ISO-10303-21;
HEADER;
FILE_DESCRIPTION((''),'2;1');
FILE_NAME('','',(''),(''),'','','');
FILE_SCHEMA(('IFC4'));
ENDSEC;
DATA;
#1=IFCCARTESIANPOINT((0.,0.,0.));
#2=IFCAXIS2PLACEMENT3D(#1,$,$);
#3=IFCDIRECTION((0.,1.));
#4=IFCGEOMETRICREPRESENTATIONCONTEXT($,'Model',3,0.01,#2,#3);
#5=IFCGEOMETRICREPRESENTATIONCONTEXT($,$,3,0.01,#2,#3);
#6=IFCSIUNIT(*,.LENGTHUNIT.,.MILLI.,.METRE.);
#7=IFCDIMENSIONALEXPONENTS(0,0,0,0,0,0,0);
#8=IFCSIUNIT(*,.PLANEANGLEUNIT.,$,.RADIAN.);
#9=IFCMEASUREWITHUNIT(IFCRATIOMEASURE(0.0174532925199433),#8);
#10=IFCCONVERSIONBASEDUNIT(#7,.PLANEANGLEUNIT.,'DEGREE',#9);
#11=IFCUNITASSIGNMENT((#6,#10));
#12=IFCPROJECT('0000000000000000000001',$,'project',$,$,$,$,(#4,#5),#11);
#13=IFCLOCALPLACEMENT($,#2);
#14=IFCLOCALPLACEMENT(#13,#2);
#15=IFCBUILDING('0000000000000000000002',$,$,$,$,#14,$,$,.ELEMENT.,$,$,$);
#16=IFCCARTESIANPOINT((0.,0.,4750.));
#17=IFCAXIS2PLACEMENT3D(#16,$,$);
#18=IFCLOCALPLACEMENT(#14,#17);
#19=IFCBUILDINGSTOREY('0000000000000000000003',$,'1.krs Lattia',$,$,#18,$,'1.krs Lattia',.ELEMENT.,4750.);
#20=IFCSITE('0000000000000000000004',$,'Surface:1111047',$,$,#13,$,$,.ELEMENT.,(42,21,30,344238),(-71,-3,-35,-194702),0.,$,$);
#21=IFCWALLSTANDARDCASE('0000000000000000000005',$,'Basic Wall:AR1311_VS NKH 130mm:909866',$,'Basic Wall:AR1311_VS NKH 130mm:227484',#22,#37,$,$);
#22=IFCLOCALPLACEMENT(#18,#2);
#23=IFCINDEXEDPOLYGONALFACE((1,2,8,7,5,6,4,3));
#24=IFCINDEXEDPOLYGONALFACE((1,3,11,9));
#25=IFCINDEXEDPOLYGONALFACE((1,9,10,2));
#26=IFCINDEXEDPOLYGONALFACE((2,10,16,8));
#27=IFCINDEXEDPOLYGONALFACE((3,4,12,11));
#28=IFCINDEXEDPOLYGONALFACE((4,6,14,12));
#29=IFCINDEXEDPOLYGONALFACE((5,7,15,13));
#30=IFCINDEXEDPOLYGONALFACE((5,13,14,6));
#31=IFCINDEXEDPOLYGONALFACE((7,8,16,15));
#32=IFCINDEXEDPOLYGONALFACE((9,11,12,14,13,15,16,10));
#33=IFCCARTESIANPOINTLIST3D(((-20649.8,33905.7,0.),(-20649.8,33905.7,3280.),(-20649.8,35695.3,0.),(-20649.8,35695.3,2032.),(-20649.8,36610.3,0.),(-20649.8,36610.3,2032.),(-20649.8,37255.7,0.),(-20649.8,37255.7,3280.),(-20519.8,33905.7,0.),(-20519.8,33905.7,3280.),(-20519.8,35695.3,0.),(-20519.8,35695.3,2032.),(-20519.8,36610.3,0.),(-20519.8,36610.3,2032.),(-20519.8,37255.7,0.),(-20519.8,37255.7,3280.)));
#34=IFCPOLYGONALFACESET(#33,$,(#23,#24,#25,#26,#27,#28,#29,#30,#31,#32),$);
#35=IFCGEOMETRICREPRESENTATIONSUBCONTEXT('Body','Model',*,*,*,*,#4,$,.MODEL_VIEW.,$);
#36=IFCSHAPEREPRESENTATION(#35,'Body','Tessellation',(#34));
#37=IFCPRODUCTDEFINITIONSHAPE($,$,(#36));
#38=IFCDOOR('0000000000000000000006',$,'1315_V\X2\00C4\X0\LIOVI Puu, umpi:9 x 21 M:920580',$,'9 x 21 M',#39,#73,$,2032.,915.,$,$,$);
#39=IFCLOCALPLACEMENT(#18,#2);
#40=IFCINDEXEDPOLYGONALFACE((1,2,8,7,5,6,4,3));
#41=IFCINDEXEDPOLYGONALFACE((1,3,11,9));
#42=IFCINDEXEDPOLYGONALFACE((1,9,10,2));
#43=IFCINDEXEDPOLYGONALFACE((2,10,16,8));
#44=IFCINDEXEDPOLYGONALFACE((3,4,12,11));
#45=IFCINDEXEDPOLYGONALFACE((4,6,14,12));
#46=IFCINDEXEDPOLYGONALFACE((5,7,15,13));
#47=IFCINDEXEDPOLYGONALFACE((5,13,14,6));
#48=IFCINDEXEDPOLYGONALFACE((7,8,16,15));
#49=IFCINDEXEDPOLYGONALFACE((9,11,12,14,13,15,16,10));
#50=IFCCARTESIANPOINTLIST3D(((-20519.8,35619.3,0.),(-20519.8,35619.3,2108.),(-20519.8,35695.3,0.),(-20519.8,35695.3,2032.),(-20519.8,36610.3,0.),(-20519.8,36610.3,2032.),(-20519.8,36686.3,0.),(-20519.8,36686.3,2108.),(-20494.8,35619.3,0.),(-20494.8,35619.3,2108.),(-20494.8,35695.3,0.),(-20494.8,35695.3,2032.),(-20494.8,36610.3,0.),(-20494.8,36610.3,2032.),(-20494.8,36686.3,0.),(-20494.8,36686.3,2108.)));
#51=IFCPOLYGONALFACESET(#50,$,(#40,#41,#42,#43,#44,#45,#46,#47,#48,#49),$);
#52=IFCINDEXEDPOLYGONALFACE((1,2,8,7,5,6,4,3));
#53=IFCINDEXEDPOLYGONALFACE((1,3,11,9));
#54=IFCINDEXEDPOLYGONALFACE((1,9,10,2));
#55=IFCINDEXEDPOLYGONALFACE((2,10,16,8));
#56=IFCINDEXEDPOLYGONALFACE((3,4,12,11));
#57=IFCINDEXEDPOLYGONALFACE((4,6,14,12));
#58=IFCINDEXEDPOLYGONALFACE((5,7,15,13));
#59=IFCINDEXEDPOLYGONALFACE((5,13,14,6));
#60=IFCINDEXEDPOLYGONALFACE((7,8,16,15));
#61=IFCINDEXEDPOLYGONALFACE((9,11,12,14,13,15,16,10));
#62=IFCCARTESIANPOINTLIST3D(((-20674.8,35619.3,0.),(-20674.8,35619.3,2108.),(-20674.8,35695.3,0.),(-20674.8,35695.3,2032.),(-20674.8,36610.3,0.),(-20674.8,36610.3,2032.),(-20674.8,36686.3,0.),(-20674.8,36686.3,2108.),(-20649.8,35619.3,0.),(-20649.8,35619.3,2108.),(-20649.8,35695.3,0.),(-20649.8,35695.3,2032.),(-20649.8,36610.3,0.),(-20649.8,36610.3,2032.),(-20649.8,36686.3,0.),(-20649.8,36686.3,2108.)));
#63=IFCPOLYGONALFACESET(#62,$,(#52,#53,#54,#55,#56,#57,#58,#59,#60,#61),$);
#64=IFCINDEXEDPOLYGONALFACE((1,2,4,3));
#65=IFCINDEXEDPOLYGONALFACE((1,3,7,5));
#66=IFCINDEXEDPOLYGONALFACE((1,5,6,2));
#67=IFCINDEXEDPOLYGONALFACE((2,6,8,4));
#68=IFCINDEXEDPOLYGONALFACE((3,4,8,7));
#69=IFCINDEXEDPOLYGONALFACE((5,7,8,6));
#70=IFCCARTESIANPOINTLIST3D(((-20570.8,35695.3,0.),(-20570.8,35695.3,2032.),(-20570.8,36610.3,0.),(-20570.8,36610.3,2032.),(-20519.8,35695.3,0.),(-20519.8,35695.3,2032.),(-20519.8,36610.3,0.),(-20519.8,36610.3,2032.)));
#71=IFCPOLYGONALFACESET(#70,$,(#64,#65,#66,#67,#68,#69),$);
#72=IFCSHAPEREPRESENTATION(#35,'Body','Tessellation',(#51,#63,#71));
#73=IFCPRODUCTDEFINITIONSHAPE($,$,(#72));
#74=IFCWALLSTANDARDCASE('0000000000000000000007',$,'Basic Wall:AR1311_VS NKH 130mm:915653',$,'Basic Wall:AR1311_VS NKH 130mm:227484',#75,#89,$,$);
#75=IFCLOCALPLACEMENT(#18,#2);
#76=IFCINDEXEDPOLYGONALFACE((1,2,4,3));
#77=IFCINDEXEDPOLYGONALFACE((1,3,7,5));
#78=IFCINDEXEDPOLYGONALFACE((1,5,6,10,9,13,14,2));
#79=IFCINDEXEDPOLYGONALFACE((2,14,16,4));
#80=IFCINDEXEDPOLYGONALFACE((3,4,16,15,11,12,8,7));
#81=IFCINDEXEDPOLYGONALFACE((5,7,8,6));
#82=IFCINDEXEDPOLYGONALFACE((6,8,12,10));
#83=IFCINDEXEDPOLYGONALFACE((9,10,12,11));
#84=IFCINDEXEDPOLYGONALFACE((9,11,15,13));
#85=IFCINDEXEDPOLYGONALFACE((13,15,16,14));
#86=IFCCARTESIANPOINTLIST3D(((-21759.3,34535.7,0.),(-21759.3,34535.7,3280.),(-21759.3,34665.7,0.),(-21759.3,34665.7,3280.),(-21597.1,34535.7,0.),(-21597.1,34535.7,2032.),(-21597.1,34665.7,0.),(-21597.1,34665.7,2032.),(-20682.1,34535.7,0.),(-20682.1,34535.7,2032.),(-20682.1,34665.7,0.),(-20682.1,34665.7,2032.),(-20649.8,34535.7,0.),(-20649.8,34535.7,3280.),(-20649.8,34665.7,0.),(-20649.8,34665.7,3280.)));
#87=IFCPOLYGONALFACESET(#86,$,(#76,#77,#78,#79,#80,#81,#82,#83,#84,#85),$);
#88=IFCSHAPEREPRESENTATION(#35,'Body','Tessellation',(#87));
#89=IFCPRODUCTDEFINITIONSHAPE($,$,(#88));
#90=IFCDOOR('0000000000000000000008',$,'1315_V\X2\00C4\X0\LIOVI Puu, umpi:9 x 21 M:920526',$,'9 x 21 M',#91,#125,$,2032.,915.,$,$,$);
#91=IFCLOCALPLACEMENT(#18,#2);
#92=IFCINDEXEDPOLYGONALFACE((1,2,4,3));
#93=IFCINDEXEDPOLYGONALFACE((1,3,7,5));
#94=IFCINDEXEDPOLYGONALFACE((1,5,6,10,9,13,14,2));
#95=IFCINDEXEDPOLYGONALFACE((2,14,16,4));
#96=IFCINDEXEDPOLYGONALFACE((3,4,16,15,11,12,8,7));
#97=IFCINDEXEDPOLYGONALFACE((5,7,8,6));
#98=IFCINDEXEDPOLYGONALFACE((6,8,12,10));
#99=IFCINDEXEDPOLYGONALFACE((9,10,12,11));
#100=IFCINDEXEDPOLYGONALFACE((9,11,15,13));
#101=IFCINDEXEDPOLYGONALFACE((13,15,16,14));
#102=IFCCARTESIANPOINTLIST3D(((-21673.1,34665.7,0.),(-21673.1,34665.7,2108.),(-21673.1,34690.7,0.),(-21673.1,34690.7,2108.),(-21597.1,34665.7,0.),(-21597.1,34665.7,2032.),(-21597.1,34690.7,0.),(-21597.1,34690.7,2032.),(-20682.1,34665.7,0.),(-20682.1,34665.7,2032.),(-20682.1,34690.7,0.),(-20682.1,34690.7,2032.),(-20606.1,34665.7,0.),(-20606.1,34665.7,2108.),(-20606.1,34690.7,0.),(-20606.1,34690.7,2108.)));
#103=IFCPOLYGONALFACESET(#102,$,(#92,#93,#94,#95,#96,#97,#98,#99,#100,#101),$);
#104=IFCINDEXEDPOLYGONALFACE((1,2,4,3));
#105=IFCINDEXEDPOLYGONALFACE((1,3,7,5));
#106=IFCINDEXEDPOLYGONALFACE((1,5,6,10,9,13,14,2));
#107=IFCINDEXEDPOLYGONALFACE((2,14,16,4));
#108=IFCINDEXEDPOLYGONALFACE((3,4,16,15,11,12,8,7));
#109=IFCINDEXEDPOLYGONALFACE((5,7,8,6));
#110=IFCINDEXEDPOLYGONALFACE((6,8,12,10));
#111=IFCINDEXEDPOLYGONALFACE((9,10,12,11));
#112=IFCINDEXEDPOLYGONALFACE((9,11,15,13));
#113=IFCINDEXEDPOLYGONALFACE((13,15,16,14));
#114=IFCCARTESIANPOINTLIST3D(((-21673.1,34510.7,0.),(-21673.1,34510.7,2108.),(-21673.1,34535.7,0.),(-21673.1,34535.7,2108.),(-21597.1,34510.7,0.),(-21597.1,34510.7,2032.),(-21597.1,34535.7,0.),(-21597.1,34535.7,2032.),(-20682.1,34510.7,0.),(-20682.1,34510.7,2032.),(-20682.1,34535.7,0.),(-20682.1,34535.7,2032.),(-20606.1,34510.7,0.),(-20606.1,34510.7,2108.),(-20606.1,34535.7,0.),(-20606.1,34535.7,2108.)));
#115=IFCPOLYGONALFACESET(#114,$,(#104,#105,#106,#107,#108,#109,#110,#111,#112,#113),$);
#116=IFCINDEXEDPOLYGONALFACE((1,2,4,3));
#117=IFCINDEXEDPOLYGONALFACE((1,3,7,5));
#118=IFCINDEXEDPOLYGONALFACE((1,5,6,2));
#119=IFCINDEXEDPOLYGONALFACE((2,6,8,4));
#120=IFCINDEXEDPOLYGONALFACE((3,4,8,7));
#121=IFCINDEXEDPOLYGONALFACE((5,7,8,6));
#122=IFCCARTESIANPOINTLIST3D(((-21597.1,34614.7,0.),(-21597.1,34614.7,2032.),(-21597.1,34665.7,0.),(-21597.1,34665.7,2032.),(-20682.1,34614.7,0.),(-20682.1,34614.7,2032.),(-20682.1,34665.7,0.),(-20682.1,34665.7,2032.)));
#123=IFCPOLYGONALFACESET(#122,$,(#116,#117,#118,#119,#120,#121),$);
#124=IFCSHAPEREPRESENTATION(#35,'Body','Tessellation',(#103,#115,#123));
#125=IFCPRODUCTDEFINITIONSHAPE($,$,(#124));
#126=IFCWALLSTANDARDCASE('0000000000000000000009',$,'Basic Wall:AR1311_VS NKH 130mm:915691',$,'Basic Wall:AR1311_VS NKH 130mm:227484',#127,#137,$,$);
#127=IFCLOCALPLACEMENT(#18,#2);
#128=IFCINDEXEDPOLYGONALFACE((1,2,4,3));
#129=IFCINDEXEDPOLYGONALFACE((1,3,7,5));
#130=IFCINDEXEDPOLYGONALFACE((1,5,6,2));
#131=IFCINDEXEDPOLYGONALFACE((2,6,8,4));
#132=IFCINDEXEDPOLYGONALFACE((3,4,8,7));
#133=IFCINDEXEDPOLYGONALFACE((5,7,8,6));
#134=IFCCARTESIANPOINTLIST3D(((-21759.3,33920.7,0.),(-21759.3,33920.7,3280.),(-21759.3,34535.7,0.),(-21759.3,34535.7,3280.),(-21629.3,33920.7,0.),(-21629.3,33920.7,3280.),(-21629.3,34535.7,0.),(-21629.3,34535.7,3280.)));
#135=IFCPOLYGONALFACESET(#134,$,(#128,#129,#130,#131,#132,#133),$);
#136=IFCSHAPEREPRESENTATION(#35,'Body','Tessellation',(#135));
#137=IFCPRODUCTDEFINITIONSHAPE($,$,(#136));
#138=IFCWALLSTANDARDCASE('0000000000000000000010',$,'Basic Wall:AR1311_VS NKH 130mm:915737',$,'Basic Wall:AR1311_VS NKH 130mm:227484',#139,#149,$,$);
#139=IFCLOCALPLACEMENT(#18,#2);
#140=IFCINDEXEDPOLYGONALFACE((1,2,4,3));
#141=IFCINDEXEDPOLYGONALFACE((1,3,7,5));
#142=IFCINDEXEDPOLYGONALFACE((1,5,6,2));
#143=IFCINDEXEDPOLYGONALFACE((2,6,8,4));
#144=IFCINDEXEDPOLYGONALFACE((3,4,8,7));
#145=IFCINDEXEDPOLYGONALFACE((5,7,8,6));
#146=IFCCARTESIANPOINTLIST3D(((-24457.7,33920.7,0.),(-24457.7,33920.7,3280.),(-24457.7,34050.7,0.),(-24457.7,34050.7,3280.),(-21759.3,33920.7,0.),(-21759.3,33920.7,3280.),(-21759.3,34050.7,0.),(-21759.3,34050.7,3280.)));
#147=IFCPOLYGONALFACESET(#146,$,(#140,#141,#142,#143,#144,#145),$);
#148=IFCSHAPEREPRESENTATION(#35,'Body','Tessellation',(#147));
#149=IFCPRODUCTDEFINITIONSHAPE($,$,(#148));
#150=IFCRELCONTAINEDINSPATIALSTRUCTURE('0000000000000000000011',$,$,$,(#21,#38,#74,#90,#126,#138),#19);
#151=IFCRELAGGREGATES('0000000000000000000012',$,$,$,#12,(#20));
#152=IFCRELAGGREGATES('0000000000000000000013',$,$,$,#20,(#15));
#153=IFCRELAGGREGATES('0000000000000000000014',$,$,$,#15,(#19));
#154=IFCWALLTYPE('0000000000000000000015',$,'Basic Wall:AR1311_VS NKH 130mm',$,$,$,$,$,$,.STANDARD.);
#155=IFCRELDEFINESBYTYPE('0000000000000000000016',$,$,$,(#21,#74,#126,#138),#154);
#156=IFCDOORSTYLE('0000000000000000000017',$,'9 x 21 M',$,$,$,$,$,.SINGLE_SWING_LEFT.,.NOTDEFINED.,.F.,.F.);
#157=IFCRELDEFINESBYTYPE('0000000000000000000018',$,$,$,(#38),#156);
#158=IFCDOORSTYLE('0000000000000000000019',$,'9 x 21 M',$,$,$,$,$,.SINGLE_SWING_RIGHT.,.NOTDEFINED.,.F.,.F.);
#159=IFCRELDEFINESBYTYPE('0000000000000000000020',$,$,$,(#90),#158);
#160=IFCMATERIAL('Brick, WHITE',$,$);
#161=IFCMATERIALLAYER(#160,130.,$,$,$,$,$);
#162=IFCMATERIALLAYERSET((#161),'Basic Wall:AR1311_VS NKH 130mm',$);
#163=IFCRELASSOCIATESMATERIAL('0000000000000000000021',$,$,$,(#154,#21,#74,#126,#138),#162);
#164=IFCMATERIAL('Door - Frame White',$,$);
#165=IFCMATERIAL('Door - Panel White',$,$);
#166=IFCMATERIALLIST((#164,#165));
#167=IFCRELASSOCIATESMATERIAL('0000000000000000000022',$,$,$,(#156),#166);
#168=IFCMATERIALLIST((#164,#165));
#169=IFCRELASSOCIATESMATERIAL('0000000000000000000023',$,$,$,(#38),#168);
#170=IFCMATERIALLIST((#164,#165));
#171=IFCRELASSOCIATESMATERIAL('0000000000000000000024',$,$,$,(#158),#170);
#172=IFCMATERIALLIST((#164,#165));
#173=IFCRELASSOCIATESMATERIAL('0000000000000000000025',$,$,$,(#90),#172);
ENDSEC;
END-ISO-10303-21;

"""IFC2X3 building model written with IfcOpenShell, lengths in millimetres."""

from ifc_helpers import new_model, entity, si_unit, converted_unit, direction, frame, frame_2d, origin, place, context, subcontext, project, spatial, polyline, rectangle, outline, extrude, clip, bounded_halfspace, source, transform, mapped, material, material_list, layer, layer_set, layer_usage, type_object, type_shapes, element, fill, save


model = new_model("IFC2X3")

# Units and contexts
model_context = context("Model", 3, precision=0.01, world=origin(), true_north=direction((0.0, 1.0)))
context_of_model = context(None, 3, precision=0.01, world=origin(), true_north=direction((0.0, 1.0)))
body_context = subcontext(model_context, "Body", "Model", "MODEL_VIEW")
ifc_project = project(units=[si_unit("LENGTHUNIT", "METRE", prefix="MILLI"), converted_unit("PLANEANGLEUNIT", "DEGREE", entity("IfcRatioMeasure", 0.0174532925199433), si_unit("PLANEANGLEUNIT", "RADIAN"), dimensions=[0, 0, 0, 0, 0, 0, 0])], contexts=[model_context, context_of_model])

# Site, building, storey
site_placement = place(None, origin())
site = spatial("IfcSite", under=ifc_project, at=site_placement, Name="Surface:1111047", CompositionType="ELEMENT", RefLatitude=(42, 21, 30, 344238), RefLongitude=(-71, -3, -35, -194702), RefElevation=0.0)
building_placement = place(site_placement, origin())
building = spatial("IfcBuilding", under=site, at=building_placement, CompositionType="ELEMENT")
storey_placement = place(building_placement, frame((0.0, 0.0, 4750.0)))
storey = spatial("IfcBuildingStorey", under=building, at=storey_placement, Name="1.krs Lattia", LongName="1.krs Lattia", CompositionType="ELEMENT", Elevation=4750.0)

# Walls, openings, doors
ifc_material_1 = material(Name="Brick, WHITE")
ifc_layer_1 = layer(ifc_material_1, 130.0)
ifc_layer_set_1 = layer_set([ifc_layer_1], Name="Basic Wall:AR1311_VS NKH 130mm")
ifc_layer_usage_1 = layer_usage(ifc_layer_set_1, "AXIS2", "NEGATIVE", 65.0)
wall_type_1 = type_object("IfcWallType", Name="Basic Wall:AR1311_VS NKH 130mm", PredefinedType="STANDARD", material=ifc_layer_set_1)
wall_1_placement = place(storey_placement, frame((-20584.8, 37255.7, 0.0), z_axis=(0.0, 0.0, 1.0), x_axis=(0.0, -1.0, 0.0)))
wall_1 = element("IfcWallStandardCase", 1, at=wall_1_placement, inside=storey, type_object=wall_type_1, material=ifc_layer_usage_1, Name="Basic Wall:AR1311_VS NKH 130mm:909866", ObjectType="Basic Wall:AR1311_VS NKH 130mm:227484", context=body_context, shape_type="Clipping", body=[
    clip(extrude(rectangle(XDim=3350.0, YDim=130.0, at=frame_2d((1675.0, 0.0), x_axis=(-1.0, 0.0))), origin(), (0.0, 0.0, 1.0), 3280.0), bounded_halfspace(frame((0.0, -65.0, 3280.0), z_axis=(0.0, 0.0, -1.0), x_axis=(-1.0, 0.0, 0.0)), True, frame((0.0, -65.0, 3280.0)), polyline([(0.0, 0.0), (2590.0, 0.0), (2720.0, 0.0), (3350.0, 0.0), (3350.0, 130.0), (3220.0, 130.0), (0.0, 130.0), (0.0, 0.0)]))),
])
opening_1_placement = place(wall_1_placement, frame((645.4, -65.0, 0.0)))
opening_1 = element("IfcOpeningElement", 2, at=opening_1_placement, cuts=wall_1, ObjectType="Opening", context=body_context, shape_type="SweptSolid", body=[
    extrude(rectangle(XDim=915.0, YDim=2032.0, at=frame_2d((1016.0, 457.5), x_axis=(0.0, -1.0))), frame((0.0, 0.0, 0.0), z_axis=(0.0, 1.0, 0.0), x_axis=(0.0, 0.0, 1.0)), (0.0, 0.0, 1.0), 130.0),
])
ifc_material_2 = material(Name="Door - Frame White")
ifc_material_3 = material(Name="Door - Panel White")
ifc_material_list_1 = material_list([ifc_material_2, ifc_material_3])
ifc_material_list_2 = material_list([ifc_material_2, ifc_material_3])
door_style_1 = type_object("IfcDoorStyle", Name="9 x 21 M", ConstructionType="NOTDEFINED", OperationType="SINGLE_SWING_LEFT", ParameterTakesPrecedence=False, Sizeable=False, material=ifc_material_list_2)
shared_shape_1 = source(origin(), body_context, "Body", "SweptSolid", [
    extrude(outline(polyline([(-533.5, -1073.0), (533.5, -1073.0), (533.5, 1035.0), (457.5, 1035.0), (457.5, -997.0), (-457.5, -997.0), (-457.5, 1035.0), (-533.5, 1035.0), (-533.5, -1073.0)])), frame((457.5, 155.0, 1035.0), z_axis=(0.0, -1.0, 0.0), x_axis=(-1.0, 0.0, 0.0)), (0.0, 0.0, 1.0), 25.0),
    extrude(outline(polyline([(-1073.0, -533.5), (1035.0, -533.5), (1035.0, -457.5), (-997.0, -457.5), (-997.0, 457.5), (1035.0, 457.5), (1035.0, 533.5), (-1073.0, 533.5), (-1073.0, -533.5)])), frame((457.5, 0.0, 1035.0), z_axis=(0.0, -1.0, 0.0), x_axis=(0.0, 0.0, -1.0)), (0.0, 0.0, 1.0), 25.0),
    extrude(rectangle(XDim=915.0, YDim=51.0, at=frame_2d((0.0, 0.0), x_axis=(1.0, 0.0))), frame((457.5, 104.5, 0.0)), (0.0, 0.0, 1.0), 2032.0),
])
type_shapes(door_style_1, [shared_shape_1])
door_1_placement = place(opening_1_placement, origin())
door_1 = element("IfcDoor", 3, at=door_1_placement, inside=storey, type_object=door_style_1, material=ifc_material_list_1, Name="1315_VÄLIOVI Puu, umpi:9 x 21 M:920580", ObjectType="9 x 21 M", OverallHeight=2032.0, OverallWidth=915.0, context=body_context, shape_type="MappedRepresentation", body=[
    mapped(shared_shape_1, transform((0.0, 0.0, 0.0), scale=1.0)),
])
fill(opening_1, door_1)
ifc_layer_usage_2 = layer_usage(ifc_layer_set_1, "AXIS2", "NEGATIVE", 65.0)
wall_2_placement = place(storey_placement, frame((-20649.8, 34600.7, 0.0), z_axis=(0.0, 0.0, 1.0), x_axis=(-1.0, 0.0, 0.0)))
wall_2 = element("IfcWallStandardCase", 4, at=wall_2_placement, inside=storey, type_object=wall_type_1, material=ifc_layer_usage_2, Name="Basic Wall:AR1311_VS NKH 130mm:915653", ObjectType="Basic Wall:AR1311_VS NKH 130mm:227484", context=body_context, shape_type="Clipping", body=[
    clip(extrude(rectangle(XDim=1109.6, YDim=130.0, at=frame_2d((554.8, 0.0), x_axis=(-1.0, 0.0))), origin(), (0.0, 0.0, 1.0), 3280.0), bounded_halfspace(frame((0.0, -65.0, 3280.0), z_axis=(0.0, 0.0, -1.0), x_axis=(0.0, -1.0, 0.0)), True, frame((0.0, -65.0, 3280.0)), polyline([(0.0, 0.0), (1109.6, 0.0), (1109.6, 130.0), (979.6, 130.0), (0.0, 130.0), (0.0, 0.0)]))),
])
opening_2_placement = place(wall_2_placement, frame((947.3, 65.0, 0.0)))
opening_2 = element("IfcOpeningElement", 5, at=opening_2_placement, cuts=wall_2, ObjectType="Opening", context=body_context, shape_type="SweptSolid", body=[
    extrude(rectangle(XDim=915.0, YDim=2032.0, at=frame_2d((1016.0, 457.5), x_axis=(0.0, 1.0))), frame((0.0, 0.0, 0.0), z_axis=(0.0, -1.0, 0.0), x_axis=(0.0, 0.0, 1.0)), (0.0, 0.0, 1.0), 130.0),
])
ifc_material_list_3 = material_list([ifc_material_2, ifc_material_3])
ifc_material_list_4 = material_list([ifc_material_2, ifc_material_3])
door_style_2 = type_object("IfcDoorStyle", Name="9 x 21 M", ConstructionType="NOTDEFINED", OperationType="SINGLE_SWING_RIGHT", ParameterTakesPrecedence=False, Sizeable=False, material=ifc_material_list_4)
shared_shape_2 = source(origin(), body_context, "Body", "SweptSolid", [
    extrude(outline(polyline([(-533.5, -1073.0), (533.5, -1073.0), (533.5, 1035.0), (457.5, 1035.0), (457.5, -997.0), (-457.5, -997.0), (-457.5, 1035.0), (-533.5, 1035.0), (-533.5, -1073.0)])), frame((457.5, 130.0, 1035.0), z_axis=(0.0, 1.0, 0.0), x_axis=(1.0, 0.0, 0.0)), (0.0, 0.0, 1.0), 25.0),
    extrude(outline(polyline([(-1073.0, -533.5), (1035.0, -533.5), (1035.0, -457.5), (-997.0, -457.5), (-997.0, 457.5), (1035.0, 457.5), (1035.0, 533.5), (-1073.0, 533.5), (-1073.0, -533.5)])), frame((457.5, -25.0, 1035.0), z_axis=(0.0, 1.0, 0.0), x_axis=(0.0, 0.0, -1.0)), (0.0, 0.0, 1.0), 25.0),
    extrude(rectangle(XDim=51.0, YDim=915.0, at=frame_2d((0.0, 0.0), x_axis=(1.0, 0.0))), frame((457.5, 104.5, 0.0), z_axis=(0.0, 0.0, 1.0), x_axis=(0.0, 1.0, 0.0)), (0.0, 0.0, 1.0), 2032.0),
])
type_shapes(door_style_2, [shared_shape_2])
door_2_placement = place(opening_2_placement, frame((0.0, 0.0, 0.0), z_axis=(0.0, 0.0, 1.0), x_axis=(-1.0, 0.0, 0.0)))
door_2 = element("IfcDoor", 6, at=door_2_placement, inside=storey, type_object=door_style_2, material=ifc_material_list_3, Name="1315_VÄLIOVI Puu, umpi:9 x 21 M:920526", ObjectType="9 x 21 M", OverallHeight=2032.0, OverallWidth=915.0, context=body_context, shape_type="MappedRepresentation", body=[
    mapped(shared_shape_2, transform((0.0, 0.0, 0.0), scale=1.0)),
])
fill(opening_2, door_2)

# Walls
ifc_layer_usage_3 = layer_usage(ifc_layer_set_1, "AXIS2", "NEGATIVE", 65.0)
wall_3_placement = place(storey_placement, frame((-21694.3, 34535.7, 0.0), z_axis=(0.0, 0.0, 1.0), x_axis=(0.0, -1.0, 0.0)))
element("IfcWallStandardCase", 7, at=wall_3_placement, inside=storey, type_object=wall_type_1, material=ifc_layer_usage_3, Name="Basic Wall:AR1311_VS NKH 130mm:915691", ObjectType="Basic Wall:AR1311_VS NKH 130mm:227484", context=body_context, shape_type="Clipping", body=[
    clip(extrude(rectangle(XDim=615.0, YDim=130.0, at=frame_2d((307.5, 0.0), x_axis=(-1.0, 0.0))), origin(), (0.0, 0.0, 1.0), 3280.0), bounded_halfspace(frame((0.0, -65.0, 3280.0), z_axis=(0.0, 0.0, -1.0), x_axis=(-1.0, 0.0, 0.0)), True, frame((0.0, -65.0, 3280.0)), polyline([(0.0, 0.0), (485.0, 0.0), (615.0, 0.0), (615.0, 130.0), (0.0, 130.0), (0.0, 0.0)]))),
])
ifc_layer_usage_4 = layer_usage(ifc_layer_set_1, "AXIS2", "NEGATIVE", 65.0)
wall_4_placement = place(storey_placement, frame((-21759.3, 33985.7, 0.0), z_axis=(0.0, 0.0, 1.0), x_axis=(-1.0, 0.0, 0.0)))
element("IfcWallStandardCase", 8, at=wall_4_placement, inside=storey, type_object=wall_type_1, material=ifc_layer_usage_4, Name="Basic Wall:AR1311_VS NKH 130mm:915737", ObjectType="Basic Wall:AR1311_VS NKH 130mm:227484", context=body_context, shape_type="Clipping", body=[
    clip(extrude(rectangle(XDim=2698.3, YDim=130.0, at=frame_2d((1349.2, 0.0), x_axis=(-1.0, 0.0))), origin(), (0.0, 0.0, 1.0), 3280.0), bounded_halfspace(frame((0.0, -65.0, 3280.0), z_axis=(0.0, 0.0, -1.0), x_axis=(0.0, -1.0, 0.0)), True, frame((0.0, -65.0, 3280.0)), polyline([(0.0, 0.0), (2568.3, 0.0), (2698.3, 0.0), (2698.3, 130.0), (0.0, 130.0), (0.0, 0.0)]))),
])

save(model, "model.ifc")
